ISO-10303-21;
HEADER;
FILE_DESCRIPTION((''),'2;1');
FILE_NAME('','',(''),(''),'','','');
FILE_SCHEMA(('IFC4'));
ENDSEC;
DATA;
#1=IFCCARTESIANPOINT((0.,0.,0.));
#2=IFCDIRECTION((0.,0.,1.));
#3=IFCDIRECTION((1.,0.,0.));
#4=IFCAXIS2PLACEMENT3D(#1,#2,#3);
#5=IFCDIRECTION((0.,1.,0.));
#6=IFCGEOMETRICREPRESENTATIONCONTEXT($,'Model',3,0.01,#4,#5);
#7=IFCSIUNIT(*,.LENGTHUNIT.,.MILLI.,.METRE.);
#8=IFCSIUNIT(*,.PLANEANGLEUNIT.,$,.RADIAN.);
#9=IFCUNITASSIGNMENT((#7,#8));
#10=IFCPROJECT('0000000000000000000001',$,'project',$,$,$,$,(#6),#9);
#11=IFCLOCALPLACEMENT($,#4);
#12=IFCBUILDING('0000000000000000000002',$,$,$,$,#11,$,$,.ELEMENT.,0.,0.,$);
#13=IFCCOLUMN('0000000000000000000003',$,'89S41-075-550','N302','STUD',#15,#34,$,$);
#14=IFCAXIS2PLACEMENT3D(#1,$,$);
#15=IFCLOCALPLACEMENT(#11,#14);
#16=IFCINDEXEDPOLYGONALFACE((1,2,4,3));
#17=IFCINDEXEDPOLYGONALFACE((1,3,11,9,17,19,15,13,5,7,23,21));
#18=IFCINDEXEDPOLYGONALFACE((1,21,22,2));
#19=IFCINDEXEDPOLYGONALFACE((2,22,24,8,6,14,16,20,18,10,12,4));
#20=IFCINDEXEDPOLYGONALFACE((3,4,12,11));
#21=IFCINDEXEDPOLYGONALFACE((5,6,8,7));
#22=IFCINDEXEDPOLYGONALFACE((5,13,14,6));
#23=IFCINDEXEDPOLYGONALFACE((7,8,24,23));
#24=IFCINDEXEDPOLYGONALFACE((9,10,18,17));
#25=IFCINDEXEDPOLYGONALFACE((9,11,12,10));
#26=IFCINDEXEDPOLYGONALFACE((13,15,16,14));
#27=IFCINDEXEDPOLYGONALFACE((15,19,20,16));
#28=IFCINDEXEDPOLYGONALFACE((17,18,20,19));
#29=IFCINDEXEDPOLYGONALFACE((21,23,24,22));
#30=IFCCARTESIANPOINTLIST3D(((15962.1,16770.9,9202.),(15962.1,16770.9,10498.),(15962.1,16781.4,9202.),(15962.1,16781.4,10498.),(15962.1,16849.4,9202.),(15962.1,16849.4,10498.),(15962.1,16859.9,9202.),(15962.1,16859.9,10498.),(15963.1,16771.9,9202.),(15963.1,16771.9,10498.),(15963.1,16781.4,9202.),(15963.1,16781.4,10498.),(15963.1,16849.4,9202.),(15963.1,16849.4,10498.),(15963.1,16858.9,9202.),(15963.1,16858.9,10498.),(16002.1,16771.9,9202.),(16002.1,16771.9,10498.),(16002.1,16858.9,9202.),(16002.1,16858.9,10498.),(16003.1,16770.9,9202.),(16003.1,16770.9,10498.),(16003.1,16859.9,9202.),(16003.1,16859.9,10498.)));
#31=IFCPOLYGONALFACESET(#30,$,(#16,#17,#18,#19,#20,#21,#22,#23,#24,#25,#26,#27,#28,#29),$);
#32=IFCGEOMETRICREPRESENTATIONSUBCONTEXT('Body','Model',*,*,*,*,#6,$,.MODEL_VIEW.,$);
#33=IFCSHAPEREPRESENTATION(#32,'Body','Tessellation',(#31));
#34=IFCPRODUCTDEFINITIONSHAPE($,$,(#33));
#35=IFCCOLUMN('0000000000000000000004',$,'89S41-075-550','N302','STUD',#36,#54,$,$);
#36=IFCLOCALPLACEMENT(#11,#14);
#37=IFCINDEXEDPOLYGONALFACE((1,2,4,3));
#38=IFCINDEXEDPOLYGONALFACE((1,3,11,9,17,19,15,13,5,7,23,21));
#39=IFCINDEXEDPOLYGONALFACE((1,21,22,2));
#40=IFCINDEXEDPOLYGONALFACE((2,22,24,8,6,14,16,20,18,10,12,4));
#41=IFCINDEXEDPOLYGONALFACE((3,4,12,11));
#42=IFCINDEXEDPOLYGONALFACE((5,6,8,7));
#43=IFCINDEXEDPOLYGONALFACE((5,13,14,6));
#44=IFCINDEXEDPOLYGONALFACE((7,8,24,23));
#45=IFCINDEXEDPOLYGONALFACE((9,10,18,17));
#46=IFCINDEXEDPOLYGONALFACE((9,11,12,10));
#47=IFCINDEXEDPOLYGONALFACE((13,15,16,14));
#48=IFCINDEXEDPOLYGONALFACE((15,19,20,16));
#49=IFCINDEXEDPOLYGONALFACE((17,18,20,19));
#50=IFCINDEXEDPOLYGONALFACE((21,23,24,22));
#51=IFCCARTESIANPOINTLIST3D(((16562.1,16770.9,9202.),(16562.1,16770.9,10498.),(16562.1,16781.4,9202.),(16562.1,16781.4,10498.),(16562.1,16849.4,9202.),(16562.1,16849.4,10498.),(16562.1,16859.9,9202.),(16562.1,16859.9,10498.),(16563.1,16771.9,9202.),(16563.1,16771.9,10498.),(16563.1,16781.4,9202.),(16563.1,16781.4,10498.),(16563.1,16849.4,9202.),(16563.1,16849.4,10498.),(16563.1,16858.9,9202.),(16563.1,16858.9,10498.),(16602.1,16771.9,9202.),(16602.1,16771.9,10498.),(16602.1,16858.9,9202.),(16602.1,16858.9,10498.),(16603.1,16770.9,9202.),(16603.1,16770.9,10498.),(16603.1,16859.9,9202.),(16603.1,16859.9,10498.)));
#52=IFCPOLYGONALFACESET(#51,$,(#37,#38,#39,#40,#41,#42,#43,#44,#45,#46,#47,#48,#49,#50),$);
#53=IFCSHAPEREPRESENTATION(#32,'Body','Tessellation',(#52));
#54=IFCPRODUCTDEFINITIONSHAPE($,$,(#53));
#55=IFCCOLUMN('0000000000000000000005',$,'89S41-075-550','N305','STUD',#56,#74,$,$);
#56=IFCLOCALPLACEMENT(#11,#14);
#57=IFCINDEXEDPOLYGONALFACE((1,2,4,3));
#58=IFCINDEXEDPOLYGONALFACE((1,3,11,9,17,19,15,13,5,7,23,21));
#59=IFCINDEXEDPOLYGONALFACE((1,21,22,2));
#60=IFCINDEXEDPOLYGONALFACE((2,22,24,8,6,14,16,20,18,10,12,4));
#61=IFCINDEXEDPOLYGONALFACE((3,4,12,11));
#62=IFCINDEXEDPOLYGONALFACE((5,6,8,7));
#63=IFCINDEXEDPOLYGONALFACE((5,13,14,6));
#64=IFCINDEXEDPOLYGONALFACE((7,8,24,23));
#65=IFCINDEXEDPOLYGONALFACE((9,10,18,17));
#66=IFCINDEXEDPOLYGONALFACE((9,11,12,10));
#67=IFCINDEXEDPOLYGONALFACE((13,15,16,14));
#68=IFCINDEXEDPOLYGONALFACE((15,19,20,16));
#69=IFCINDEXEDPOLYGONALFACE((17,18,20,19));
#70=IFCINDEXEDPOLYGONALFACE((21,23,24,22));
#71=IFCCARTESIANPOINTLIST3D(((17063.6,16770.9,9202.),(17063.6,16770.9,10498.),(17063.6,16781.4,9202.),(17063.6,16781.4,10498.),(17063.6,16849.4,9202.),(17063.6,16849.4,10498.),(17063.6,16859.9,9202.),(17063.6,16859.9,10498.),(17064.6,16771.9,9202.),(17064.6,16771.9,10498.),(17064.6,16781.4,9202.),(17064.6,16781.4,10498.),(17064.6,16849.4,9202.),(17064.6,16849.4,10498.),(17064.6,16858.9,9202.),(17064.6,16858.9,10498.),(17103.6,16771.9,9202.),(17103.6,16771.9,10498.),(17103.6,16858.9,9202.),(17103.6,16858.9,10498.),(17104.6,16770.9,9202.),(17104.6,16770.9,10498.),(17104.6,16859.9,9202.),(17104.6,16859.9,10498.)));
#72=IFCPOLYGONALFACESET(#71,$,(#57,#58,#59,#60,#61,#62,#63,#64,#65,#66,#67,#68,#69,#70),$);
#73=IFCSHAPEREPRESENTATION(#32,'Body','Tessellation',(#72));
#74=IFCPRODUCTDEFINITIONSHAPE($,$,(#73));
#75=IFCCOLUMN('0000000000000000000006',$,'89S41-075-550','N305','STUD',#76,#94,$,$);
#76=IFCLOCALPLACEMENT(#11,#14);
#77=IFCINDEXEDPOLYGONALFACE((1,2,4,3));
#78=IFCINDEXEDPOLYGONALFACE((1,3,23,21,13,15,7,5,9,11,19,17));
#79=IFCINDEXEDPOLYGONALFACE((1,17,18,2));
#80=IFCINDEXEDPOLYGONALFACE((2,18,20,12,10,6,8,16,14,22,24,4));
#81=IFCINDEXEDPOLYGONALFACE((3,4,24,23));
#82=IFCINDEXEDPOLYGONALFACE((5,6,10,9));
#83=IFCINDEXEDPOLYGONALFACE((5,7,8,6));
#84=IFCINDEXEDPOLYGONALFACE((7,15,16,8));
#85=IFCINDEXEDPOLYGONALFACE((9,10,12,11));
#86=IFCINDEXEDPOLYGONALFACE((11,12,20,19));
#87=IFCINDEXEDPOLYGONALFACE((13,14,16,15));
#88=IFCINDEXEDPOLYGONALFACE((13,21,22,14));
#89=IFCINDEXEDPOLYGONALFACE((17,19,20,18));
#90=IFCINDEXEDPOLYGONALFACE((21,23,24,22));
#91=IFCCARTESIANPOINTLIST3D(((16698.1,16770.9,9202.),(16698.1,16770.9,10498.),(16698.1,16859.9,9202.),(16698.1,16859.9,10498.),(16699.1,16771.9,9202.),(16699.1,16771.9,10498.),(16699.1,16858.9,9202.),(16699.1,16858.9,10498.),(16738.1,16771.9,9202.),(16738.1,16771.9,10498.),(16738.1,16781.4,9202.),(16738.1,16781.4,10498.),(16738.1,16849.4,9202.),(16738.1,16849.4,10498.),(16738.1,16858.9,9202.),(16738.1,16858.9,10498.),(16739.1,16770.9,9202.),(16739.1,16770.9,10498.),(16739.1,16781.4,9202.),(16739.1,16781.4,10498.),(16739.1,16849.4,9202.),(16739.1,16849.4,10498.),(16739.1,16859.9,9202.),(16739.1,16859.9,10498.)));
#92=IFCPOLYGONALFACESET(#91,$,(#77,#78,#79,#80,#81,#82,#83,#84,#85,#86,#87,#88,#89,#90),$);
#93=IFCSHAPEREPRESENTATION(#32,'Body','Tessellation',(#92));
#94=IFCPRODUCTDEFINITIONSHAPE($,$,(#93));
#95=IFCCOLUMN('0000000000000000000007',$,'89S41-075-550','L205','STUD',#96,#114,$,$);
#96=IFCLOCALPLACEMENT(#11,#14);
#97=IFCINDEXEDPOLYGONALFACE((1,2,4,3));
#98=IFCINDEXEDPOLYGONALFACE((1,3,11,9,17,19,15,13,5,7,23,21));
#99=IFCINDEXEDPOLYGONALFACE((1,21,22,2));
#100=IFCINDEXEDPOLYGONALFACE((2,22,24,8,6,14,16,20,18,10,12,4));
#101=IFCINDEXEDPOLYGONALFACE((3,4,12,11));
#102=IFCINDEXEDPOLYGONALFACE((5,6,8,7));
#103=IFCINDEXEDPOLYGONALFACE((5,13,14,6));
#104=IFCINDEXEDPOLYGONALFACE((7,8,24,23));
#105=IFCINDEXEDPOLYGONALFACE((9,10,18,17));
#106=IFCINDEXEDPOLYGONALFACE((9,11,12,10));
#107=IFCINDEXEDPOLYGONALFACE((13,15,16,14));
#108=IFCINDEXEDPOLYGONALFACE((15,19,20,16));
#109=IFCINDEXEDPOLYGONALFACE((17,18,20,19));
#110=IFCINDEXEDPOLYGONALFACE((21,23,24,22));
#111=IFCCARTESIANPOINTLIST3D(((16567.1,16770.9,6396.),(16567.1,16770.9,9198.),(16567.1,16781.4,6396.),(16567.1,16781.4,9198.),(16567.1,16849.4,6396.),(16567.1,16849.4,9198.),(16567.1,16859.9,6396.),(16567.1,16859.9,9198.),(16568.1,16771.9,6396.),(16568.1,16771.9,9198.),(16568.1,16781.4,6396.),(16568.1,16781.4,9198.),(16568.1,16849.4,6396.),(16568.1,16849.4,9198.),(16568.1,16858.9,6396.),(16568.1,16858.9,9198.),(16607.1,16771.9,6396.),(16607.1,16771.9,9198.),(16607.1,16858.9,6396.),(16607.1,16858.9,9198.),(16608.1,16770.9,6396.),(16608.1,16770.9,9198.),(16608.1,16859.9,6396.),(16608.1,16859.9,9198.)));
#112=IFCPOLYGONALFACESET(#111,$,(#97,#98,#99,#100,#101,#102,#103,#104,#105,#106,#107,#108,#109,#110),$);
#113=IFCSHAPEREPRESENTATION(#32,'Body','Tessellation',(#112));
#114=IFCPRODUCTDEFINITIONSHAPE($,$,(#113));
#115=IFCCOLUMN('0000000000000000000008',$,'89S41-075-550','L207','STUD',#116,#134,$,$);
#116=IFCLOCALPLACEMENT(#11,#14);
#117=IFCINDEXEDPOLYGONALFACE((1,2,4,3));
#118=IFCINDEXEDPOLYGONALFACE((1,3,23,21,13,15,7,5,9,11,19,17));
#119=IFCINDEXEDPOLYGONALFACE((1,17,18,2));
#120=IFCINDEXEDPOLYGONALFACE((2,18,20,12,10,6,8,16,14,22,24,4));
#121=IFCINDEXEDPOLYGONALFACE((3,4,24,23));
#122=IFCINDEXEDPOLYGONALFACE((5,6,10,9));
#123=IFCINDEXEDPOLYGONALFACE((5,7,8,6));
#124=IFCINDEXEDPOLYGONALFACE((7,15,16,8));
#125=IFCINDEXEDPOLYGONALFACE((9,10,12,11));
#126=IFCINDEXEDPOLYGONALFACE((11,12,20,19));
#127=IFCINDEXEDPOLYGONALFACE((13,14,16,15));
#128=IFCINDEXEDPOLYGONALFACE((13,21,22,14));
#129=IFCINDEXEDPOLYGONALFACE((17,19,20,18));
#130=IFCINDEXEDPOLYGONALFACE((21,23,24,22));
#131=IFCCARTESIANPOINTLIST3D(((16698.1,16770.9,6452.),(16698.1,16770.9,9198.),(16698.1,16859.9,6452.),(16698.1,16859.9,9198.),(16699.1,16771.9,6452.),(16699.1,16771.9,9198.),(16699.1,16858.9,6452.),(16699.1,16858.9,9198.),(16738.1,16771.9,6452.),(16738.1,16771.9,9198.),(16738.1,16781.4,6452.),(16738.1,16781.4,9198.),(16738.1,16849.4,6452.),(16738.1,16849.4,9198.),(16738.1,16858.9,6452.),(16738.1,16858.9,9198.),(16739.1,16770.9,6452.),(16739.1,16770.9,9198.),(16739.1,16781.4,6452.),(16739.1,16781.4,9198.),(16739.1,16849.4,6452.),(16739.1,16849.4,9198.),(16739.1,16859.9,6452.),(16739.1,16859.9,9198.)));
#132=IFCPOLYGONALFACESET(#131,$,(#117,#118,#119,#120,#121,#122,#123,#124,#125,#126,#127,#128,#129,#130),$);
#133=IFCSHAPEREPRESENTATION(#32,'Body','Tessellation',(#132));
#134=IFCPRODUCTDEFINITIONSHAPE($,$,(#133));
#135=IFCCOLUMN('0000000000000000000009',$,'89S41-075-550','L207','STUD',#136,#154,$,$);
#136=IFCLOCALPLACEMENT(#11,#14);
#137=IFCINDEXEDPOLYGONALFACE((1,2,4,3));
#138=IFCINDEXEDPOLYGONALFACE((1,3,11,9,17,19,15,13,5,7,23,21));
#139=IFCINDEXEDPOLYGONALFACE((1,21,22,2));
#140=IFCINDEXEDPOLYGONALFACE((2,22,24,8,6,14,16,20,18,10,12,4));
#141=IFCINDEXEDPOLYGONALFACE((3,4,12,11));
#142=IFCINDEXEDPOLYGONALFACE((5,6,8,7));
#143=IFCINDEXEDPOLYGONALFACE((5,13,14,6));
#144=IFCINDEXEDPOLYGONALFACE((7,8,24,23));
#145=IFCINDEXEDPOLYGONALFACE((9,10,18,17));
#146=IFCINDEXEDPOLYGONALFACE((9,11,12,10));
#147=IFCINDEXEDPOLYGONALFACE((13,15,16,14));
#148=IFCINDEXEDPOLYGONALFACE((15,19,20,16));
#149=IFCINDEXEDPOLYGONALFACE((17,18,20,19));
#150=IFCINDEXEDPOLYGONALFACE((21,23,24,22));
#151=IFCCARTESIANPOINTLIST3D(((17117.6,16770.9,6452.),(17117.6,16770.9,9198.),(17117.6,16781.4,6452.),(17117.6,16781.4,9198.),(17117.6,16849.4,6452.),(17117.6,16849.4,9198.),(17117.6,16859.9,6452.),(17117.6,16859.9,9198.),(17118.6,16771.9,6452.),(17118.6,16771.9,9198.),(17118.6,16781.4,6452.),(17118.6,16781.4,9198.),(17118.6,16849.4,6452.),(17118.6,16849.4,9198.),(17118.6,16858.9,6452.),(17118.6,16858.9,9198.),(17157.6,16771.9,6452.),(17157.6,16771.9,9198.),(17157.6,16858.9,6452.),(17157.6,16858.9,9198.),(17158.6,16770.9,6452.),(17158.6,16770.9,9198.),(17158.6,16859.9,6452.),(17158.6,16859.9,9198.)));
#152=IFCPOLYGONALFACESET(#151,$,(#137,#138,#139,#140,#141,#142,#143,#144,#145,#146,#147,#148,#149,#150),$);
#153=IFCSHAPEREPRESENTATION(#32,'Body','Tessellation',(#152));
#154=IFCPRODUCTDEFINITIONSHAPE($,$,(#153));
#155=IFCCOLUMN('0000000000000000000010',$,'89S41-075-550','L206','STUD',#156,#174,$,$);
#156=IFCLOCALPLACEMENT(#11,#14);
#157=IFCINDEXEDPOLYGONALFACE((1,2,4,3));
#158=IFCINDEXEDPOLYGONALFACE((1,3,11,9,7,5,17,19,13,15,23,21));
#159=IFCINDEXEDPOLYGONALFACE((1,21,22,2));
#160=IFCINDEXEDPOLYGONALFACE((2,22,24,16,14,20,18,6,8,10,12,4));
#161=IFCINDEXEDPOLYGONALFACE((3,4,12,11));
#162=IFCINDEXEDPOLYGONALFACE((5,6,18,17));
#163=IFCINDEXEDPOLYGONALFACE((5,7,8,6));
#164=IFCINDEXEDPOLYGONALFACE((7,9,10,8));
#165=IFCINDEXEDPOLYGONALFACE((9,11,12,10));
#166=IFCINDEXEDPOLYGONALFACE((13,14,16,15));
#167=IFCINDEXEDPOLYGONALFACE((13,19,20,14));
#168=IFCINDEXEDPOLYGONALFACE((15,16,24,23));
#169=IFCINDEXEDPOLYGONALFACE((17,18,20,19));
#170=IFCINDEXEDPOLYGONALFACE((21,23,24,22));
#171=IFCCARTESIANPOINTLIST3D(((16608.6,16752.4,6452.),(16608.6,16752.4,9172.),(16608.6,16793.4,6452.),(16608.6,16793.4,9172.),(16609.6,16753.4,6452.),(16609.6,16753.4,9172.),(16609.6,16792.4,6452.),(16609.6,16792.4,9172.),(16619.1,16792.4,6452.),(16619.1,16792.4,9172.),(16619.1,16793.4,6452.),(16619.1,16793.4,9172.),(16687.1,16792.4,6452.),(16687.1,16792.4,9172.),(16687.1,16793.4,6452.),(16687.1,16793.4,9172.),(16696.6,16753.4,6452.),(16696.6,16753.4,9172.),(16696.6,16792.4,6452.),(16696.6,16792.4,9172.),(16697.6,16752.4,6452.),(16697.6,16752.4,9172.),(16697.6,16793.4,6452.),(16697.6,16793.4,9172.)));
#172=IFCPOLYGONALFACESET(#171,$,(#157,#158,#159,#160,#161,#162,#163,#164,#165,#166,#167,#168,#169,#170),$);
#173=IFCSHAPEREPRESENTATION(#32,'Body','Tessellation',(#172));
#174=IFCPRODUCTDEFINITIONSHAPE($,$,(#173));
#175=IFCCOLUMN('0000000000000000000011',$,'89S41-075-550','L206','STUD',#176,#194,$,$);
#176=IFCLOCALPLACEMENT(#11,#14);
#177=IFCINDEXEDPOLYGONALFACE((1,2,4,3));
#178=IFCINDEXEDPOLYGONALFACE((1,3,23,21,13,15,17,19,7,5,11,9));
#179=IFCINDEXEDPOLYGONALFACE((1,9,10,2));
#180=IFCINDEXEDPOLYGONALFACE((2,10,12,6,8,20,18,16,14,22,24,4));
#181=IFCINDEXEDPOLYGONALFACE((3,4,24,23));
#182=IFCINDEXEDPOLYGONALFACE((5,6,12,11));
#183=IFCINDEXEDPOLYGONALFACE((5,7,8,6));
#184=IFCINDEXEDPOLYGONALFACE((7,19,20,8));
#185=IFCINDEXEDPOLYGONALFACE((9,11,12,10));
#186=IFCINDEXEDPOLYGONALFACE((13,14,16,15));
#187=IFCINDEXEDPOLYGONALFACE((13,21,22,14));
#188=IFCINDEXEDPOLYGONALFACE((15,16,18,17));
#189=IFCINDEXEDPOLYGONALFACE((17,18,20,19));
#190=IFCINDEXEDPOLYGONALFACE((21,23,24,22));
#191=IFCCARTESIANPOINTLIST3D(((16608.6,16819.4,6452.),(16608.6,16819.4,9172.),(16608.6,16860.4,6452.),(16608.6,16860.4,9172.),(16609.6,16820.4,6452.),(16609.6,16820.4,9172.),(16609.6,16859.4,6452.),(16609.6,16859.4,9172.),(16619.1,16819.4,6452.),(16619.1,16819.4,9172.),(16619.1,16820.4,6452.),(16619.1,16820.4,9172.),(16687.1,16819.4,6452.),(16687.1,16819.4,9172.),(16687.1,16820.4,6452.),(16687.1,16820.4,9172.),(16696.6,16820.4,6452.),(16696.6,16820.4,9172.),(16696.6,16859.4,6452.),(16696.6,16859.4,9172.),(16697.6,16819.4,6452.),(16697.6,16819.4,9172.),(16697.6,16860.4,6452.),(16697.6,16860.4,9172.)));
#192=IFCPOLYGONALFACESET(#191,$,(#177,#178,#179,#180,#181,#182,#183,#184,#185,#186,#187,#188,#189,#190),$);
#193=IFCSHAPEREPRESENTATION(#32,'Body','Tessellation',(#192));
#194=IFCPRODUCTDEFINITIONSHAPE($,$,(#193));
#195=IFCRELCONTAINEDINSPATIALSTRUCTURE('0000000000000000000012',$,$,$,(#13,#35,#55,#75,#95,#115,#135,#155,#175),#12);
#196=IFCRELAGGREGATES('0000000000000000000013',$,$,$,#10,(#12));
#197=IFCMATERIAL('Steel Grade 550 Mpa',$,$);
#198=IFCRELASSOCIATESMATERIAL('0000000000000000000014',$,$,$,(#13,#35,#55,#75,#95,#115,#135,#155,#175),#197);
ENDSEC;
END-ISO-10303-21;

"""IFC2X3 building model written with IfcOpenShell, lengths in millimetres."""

from ifc_helpers import new_model, si_unit, direction, frame, origin, origin_with_axes, origin_2d_with_axis, place, context, subcontext, project, spatial, c_section, extrude, source, transform, mapped, material, element, save


model = new_model("IFC2X3")

# Units and contexts
model_context = context("Model", 3, precision=0.01, world=origin_with_axes(), true_north=direction((0.0, 1.0, 0.0)))
body_context = subcontext(model_context, "Body", "Model", "MODEL_VIEW")
ifc_project = project(units=[si_unit("LENGTHUNIT", "METRE", prefix="MILLI"), si_unit("PLANEANGLEUNIT", "RADIAN")], contexts=[model_context])

# Building
building_placement = place(None, origin_with_axes())
building = spatial("IfcBuilding", under=ifc_project, at=building_placement, CompositionType="ELEMENT", ElevationOfRefHeight=0.0, ElevationOfTerrain=0.0)

# Columns
ifc_material = material(Name="Steel Grade 550 Mpa")
shared_shape_1 = source(origin(), body_context, "Body", "SweptSolid", [
    extrude(c_section(Depth=89.0, Width=41.0, WallThickness=1.0, Girth=10.5, at=origin_2d_with_axis()), origin_with_axes(), (0.0, 0.0, 1.0), 1296.0),
])
column_1_placement = place(None, frame((15982.6, 16815.4, 9202.0), z_axis=(0.0, 0.0, 1.0), x_axis=(-1.0, 0.0, 0.0)))
element("IfcColumn", 1, at=column_1_placement, inside=building, material=ifc_material, Name="89S41-075-550", Description="N302", ObjectType="STUD", context=body_context, shape_type="MappedRepresentation", body=[
    mapped(shared_shape_1, transform((0.0, 0.0, 0.0), scale=1.0)),
])
shared_shape_2 = source(origin(), body_context, "Body", "SweptSolid", [
    extrude(c_section(Depth=89.0, Width=41.0, WallThickness=1.0, Girth=10.5, at=origin_2d_with_axis()), origin_with_axes(), (0.0, 0.0, 1.0), 1296.0),
])
column_2_placement = place(None, frame((16582.6, 16815.4, 9202.0), z_axis=(0.0, 0.0, 1.0), x_axis=(-1.0, 0.0, 0.0)))
element("IfcColumn", 2, at=column_2_placement, inside=building, material=ifc_material, Name="89S41-075-550", Description="N302", ObjectType="STUD", context=body_context, shape_type="MappedRepresentation", body=[
    mapped(shared_shape_2, transform((0.0, 0.0, 0.0), scale=1.0)),
])
shared_shape_3 = source(origin(), body_context, "Body", "SweptSolid", [
    extrude(c_section(Depth=89.0, Width=41.0, WallThickness=1.0, Girth=10.5, at=origin_2d_with_axis()), origin_with_axes(), (0.0, 0.0, 1.0), 1296.0),
])
column_3_placement = place(None, frame((17084.1, 16815.4, 9202.0), z_axis=(0.0, 0.0, 1.0), x_axis=(-1.0, 0.0, 0.0)))
element("IfcColumn", 3, at=column_3_placement, inside=building, material=ifc_material, Name="89S41-075-550", Description="N305", ObjectType="STUD", context=body_context, shape_type="MappedRepresentation", body=[
    mapped(shared_shape_3, transform((0.0, 0.0, 0.0), scale=1.0)),
])
shared_shape_4 = source(origin(), body_context, "Body", "SweptSolid", [
    extrude(c_section(Depth=89.0, Width=41.0, WallThickness=1.0, Girth=10.5, at=origin_2d_with_axis()), origin_with_axes(), (0.0, 0.0, 1.0), 1296.0),
])
column_4_placement = place(None, frame((16718.6, 16815.4, 9202.0), z_axis=(0.0, 0.0, 1.0), x_axis=(1.0, 0.0, 0.0)))
element("IfcColumn", 4, at=column_4_placement, inside=building, material=ifc_material, Name="89S41-075-550", Description="N305", ObjectType="STUD", context=body_context, shape_type="MappedRepresentation", body=[
    mapped(shared_shape_4, transform((0.0, 0.0, 0.0), scale=1.0)),
])
shared_shape_5 = source(origin(), body_context, "Body", "SweptSolid", [
    extrude(c_section(Depth=89.0, Width=41.0, WallThickness=1.0, Girth=10.5, at=origin_2d_with_axis()), origin_with_axes(), (0.0, 0.0, 1.0), 2802.0),
])
column_5_placement = place(None, frame((16587.6, 16815.4, 6396.0), z_axis=(0.0, 0.0, 1.0), x_axis=(-1.0, 0.0, 0.0)))
element("IfcColumn", 5, at=column_5_placement, inside=building, material=ifc_material, Name="89S41-075-550", Description="L205", ObjectType="STUD", context=body_context, shape_type="MappedRepresentation", body=[
    mapped(shared_shape_5, transform((0.0, 0.0, 0.0), scale=1.0)),
])
shared_shape_6 = source(origin(), body_context, "Body", "SweptSolid", [
    extrude(c_section(Depth=89.0, Width=41.0, WallThickness=1.0, Girth=10.5, at=origin_2d_with_axis()), origin_with_axes(), (0.0, 0.0, 1.0), 2746.0),
])
column_6_placement = place(None, frame((16718.6, 16815.4, 6452.0), z_axis=(0.0, 0.0, 1.0), x_axis=(1.0, 0.0, 0.0)))
element("IfcColumn", 6, at=column_6_placement, inside=building, material=ifc_material, Name="89S41-075-550", Description="L207", ObjectType="STUD", context=body_context, shape_type="MappedRepresentation", body=[
    mapped(shared_shape_6, transform((0.0, 0.0, 0.0), scale=1.0)),
])
shared_shape_7 = source(origin(), body_context, "Body", "SweptSolid", [
    extrude(c_section(Depth=89.0, Width=41.0, WallThickness=1.0, Girth=10.5, at=origin_2d_with_axis()), origin_with_axes(), (0.0, 0.0, 1.0), 2746.0),
])
column_7_placement = place(None, frame((17138.1, 16815.4, 6452.0), z_axis=(0.0, 0.0, 1.0), x_axis=(-1.0, 0.0, 0.0)))
element("IfcColumn", 7, at=column_7_placement, inside=building, material=ifc_material, Name="89S41-075-550", Description="L207", ObjectType="STUD", context=body_context, shape_type="MappedRepresentation", body=[
    mapped(shared_shape_7, transform((0.0, 0.0, 0.0), scale=1.0)),
])
shared_shape_8 = source(origin(), body_context, "Body", "SweptSolid", [
    extrude(c_section(Depth=89.0, Width=41.0, WallThickness=1.0, Girth=10.5, at=origin_2d_with_axis()), origin_with_axes(), (0.0, 0.0, 1.0), 2720.0),
])
column_8_placement = place(None, frame((16653.1, 16772.9, 6452.0), z_axis=(0.0, 0.0, 1.0), x_axis=(0.0, 1.0, 0.0)))
element("IfcColumn", 8, at=column_8_placement, inside=building, material=ifc_material, Name="89S41-075-550", Description="L206", ObjectType="STUD", context=body_context, shape_type="MappedRepresentation", body=[
    mapped(shared_shape_8, transform((0.0, 0.0, 0.0), scale=1.0)),
])
shared_shape_9 = source(origin(), body_context, "Body", "SweptSolid", [
    extrude(c_section(Depth=89.0, Width=41.0, WallThickness=1.0, Girth=10.5, at=origin_2d_with_axis()), origin_with_axes(), (0.0, 0.0, 1.0), 2720.0),
])
column_9_placement = place(None, frame((16653.1, 16839.9, 6452.0), z_axis=(0.0, 0.0, 1.0), x_axis=(0.0, -1.0, 0.0)))
element("IfcColumn", 9, at=column_9_placement, inside=building, material=ifc_material, Name="89S41-075-550", Description="L206", ObjectType="STUD", context=body_context, shape_type="MappedRepresentation", body=[
    mapped(shared_shape_9, transform((0.0, 0.0, 0.0), scale=1.0)),
])

save(model, "model.ifc")
